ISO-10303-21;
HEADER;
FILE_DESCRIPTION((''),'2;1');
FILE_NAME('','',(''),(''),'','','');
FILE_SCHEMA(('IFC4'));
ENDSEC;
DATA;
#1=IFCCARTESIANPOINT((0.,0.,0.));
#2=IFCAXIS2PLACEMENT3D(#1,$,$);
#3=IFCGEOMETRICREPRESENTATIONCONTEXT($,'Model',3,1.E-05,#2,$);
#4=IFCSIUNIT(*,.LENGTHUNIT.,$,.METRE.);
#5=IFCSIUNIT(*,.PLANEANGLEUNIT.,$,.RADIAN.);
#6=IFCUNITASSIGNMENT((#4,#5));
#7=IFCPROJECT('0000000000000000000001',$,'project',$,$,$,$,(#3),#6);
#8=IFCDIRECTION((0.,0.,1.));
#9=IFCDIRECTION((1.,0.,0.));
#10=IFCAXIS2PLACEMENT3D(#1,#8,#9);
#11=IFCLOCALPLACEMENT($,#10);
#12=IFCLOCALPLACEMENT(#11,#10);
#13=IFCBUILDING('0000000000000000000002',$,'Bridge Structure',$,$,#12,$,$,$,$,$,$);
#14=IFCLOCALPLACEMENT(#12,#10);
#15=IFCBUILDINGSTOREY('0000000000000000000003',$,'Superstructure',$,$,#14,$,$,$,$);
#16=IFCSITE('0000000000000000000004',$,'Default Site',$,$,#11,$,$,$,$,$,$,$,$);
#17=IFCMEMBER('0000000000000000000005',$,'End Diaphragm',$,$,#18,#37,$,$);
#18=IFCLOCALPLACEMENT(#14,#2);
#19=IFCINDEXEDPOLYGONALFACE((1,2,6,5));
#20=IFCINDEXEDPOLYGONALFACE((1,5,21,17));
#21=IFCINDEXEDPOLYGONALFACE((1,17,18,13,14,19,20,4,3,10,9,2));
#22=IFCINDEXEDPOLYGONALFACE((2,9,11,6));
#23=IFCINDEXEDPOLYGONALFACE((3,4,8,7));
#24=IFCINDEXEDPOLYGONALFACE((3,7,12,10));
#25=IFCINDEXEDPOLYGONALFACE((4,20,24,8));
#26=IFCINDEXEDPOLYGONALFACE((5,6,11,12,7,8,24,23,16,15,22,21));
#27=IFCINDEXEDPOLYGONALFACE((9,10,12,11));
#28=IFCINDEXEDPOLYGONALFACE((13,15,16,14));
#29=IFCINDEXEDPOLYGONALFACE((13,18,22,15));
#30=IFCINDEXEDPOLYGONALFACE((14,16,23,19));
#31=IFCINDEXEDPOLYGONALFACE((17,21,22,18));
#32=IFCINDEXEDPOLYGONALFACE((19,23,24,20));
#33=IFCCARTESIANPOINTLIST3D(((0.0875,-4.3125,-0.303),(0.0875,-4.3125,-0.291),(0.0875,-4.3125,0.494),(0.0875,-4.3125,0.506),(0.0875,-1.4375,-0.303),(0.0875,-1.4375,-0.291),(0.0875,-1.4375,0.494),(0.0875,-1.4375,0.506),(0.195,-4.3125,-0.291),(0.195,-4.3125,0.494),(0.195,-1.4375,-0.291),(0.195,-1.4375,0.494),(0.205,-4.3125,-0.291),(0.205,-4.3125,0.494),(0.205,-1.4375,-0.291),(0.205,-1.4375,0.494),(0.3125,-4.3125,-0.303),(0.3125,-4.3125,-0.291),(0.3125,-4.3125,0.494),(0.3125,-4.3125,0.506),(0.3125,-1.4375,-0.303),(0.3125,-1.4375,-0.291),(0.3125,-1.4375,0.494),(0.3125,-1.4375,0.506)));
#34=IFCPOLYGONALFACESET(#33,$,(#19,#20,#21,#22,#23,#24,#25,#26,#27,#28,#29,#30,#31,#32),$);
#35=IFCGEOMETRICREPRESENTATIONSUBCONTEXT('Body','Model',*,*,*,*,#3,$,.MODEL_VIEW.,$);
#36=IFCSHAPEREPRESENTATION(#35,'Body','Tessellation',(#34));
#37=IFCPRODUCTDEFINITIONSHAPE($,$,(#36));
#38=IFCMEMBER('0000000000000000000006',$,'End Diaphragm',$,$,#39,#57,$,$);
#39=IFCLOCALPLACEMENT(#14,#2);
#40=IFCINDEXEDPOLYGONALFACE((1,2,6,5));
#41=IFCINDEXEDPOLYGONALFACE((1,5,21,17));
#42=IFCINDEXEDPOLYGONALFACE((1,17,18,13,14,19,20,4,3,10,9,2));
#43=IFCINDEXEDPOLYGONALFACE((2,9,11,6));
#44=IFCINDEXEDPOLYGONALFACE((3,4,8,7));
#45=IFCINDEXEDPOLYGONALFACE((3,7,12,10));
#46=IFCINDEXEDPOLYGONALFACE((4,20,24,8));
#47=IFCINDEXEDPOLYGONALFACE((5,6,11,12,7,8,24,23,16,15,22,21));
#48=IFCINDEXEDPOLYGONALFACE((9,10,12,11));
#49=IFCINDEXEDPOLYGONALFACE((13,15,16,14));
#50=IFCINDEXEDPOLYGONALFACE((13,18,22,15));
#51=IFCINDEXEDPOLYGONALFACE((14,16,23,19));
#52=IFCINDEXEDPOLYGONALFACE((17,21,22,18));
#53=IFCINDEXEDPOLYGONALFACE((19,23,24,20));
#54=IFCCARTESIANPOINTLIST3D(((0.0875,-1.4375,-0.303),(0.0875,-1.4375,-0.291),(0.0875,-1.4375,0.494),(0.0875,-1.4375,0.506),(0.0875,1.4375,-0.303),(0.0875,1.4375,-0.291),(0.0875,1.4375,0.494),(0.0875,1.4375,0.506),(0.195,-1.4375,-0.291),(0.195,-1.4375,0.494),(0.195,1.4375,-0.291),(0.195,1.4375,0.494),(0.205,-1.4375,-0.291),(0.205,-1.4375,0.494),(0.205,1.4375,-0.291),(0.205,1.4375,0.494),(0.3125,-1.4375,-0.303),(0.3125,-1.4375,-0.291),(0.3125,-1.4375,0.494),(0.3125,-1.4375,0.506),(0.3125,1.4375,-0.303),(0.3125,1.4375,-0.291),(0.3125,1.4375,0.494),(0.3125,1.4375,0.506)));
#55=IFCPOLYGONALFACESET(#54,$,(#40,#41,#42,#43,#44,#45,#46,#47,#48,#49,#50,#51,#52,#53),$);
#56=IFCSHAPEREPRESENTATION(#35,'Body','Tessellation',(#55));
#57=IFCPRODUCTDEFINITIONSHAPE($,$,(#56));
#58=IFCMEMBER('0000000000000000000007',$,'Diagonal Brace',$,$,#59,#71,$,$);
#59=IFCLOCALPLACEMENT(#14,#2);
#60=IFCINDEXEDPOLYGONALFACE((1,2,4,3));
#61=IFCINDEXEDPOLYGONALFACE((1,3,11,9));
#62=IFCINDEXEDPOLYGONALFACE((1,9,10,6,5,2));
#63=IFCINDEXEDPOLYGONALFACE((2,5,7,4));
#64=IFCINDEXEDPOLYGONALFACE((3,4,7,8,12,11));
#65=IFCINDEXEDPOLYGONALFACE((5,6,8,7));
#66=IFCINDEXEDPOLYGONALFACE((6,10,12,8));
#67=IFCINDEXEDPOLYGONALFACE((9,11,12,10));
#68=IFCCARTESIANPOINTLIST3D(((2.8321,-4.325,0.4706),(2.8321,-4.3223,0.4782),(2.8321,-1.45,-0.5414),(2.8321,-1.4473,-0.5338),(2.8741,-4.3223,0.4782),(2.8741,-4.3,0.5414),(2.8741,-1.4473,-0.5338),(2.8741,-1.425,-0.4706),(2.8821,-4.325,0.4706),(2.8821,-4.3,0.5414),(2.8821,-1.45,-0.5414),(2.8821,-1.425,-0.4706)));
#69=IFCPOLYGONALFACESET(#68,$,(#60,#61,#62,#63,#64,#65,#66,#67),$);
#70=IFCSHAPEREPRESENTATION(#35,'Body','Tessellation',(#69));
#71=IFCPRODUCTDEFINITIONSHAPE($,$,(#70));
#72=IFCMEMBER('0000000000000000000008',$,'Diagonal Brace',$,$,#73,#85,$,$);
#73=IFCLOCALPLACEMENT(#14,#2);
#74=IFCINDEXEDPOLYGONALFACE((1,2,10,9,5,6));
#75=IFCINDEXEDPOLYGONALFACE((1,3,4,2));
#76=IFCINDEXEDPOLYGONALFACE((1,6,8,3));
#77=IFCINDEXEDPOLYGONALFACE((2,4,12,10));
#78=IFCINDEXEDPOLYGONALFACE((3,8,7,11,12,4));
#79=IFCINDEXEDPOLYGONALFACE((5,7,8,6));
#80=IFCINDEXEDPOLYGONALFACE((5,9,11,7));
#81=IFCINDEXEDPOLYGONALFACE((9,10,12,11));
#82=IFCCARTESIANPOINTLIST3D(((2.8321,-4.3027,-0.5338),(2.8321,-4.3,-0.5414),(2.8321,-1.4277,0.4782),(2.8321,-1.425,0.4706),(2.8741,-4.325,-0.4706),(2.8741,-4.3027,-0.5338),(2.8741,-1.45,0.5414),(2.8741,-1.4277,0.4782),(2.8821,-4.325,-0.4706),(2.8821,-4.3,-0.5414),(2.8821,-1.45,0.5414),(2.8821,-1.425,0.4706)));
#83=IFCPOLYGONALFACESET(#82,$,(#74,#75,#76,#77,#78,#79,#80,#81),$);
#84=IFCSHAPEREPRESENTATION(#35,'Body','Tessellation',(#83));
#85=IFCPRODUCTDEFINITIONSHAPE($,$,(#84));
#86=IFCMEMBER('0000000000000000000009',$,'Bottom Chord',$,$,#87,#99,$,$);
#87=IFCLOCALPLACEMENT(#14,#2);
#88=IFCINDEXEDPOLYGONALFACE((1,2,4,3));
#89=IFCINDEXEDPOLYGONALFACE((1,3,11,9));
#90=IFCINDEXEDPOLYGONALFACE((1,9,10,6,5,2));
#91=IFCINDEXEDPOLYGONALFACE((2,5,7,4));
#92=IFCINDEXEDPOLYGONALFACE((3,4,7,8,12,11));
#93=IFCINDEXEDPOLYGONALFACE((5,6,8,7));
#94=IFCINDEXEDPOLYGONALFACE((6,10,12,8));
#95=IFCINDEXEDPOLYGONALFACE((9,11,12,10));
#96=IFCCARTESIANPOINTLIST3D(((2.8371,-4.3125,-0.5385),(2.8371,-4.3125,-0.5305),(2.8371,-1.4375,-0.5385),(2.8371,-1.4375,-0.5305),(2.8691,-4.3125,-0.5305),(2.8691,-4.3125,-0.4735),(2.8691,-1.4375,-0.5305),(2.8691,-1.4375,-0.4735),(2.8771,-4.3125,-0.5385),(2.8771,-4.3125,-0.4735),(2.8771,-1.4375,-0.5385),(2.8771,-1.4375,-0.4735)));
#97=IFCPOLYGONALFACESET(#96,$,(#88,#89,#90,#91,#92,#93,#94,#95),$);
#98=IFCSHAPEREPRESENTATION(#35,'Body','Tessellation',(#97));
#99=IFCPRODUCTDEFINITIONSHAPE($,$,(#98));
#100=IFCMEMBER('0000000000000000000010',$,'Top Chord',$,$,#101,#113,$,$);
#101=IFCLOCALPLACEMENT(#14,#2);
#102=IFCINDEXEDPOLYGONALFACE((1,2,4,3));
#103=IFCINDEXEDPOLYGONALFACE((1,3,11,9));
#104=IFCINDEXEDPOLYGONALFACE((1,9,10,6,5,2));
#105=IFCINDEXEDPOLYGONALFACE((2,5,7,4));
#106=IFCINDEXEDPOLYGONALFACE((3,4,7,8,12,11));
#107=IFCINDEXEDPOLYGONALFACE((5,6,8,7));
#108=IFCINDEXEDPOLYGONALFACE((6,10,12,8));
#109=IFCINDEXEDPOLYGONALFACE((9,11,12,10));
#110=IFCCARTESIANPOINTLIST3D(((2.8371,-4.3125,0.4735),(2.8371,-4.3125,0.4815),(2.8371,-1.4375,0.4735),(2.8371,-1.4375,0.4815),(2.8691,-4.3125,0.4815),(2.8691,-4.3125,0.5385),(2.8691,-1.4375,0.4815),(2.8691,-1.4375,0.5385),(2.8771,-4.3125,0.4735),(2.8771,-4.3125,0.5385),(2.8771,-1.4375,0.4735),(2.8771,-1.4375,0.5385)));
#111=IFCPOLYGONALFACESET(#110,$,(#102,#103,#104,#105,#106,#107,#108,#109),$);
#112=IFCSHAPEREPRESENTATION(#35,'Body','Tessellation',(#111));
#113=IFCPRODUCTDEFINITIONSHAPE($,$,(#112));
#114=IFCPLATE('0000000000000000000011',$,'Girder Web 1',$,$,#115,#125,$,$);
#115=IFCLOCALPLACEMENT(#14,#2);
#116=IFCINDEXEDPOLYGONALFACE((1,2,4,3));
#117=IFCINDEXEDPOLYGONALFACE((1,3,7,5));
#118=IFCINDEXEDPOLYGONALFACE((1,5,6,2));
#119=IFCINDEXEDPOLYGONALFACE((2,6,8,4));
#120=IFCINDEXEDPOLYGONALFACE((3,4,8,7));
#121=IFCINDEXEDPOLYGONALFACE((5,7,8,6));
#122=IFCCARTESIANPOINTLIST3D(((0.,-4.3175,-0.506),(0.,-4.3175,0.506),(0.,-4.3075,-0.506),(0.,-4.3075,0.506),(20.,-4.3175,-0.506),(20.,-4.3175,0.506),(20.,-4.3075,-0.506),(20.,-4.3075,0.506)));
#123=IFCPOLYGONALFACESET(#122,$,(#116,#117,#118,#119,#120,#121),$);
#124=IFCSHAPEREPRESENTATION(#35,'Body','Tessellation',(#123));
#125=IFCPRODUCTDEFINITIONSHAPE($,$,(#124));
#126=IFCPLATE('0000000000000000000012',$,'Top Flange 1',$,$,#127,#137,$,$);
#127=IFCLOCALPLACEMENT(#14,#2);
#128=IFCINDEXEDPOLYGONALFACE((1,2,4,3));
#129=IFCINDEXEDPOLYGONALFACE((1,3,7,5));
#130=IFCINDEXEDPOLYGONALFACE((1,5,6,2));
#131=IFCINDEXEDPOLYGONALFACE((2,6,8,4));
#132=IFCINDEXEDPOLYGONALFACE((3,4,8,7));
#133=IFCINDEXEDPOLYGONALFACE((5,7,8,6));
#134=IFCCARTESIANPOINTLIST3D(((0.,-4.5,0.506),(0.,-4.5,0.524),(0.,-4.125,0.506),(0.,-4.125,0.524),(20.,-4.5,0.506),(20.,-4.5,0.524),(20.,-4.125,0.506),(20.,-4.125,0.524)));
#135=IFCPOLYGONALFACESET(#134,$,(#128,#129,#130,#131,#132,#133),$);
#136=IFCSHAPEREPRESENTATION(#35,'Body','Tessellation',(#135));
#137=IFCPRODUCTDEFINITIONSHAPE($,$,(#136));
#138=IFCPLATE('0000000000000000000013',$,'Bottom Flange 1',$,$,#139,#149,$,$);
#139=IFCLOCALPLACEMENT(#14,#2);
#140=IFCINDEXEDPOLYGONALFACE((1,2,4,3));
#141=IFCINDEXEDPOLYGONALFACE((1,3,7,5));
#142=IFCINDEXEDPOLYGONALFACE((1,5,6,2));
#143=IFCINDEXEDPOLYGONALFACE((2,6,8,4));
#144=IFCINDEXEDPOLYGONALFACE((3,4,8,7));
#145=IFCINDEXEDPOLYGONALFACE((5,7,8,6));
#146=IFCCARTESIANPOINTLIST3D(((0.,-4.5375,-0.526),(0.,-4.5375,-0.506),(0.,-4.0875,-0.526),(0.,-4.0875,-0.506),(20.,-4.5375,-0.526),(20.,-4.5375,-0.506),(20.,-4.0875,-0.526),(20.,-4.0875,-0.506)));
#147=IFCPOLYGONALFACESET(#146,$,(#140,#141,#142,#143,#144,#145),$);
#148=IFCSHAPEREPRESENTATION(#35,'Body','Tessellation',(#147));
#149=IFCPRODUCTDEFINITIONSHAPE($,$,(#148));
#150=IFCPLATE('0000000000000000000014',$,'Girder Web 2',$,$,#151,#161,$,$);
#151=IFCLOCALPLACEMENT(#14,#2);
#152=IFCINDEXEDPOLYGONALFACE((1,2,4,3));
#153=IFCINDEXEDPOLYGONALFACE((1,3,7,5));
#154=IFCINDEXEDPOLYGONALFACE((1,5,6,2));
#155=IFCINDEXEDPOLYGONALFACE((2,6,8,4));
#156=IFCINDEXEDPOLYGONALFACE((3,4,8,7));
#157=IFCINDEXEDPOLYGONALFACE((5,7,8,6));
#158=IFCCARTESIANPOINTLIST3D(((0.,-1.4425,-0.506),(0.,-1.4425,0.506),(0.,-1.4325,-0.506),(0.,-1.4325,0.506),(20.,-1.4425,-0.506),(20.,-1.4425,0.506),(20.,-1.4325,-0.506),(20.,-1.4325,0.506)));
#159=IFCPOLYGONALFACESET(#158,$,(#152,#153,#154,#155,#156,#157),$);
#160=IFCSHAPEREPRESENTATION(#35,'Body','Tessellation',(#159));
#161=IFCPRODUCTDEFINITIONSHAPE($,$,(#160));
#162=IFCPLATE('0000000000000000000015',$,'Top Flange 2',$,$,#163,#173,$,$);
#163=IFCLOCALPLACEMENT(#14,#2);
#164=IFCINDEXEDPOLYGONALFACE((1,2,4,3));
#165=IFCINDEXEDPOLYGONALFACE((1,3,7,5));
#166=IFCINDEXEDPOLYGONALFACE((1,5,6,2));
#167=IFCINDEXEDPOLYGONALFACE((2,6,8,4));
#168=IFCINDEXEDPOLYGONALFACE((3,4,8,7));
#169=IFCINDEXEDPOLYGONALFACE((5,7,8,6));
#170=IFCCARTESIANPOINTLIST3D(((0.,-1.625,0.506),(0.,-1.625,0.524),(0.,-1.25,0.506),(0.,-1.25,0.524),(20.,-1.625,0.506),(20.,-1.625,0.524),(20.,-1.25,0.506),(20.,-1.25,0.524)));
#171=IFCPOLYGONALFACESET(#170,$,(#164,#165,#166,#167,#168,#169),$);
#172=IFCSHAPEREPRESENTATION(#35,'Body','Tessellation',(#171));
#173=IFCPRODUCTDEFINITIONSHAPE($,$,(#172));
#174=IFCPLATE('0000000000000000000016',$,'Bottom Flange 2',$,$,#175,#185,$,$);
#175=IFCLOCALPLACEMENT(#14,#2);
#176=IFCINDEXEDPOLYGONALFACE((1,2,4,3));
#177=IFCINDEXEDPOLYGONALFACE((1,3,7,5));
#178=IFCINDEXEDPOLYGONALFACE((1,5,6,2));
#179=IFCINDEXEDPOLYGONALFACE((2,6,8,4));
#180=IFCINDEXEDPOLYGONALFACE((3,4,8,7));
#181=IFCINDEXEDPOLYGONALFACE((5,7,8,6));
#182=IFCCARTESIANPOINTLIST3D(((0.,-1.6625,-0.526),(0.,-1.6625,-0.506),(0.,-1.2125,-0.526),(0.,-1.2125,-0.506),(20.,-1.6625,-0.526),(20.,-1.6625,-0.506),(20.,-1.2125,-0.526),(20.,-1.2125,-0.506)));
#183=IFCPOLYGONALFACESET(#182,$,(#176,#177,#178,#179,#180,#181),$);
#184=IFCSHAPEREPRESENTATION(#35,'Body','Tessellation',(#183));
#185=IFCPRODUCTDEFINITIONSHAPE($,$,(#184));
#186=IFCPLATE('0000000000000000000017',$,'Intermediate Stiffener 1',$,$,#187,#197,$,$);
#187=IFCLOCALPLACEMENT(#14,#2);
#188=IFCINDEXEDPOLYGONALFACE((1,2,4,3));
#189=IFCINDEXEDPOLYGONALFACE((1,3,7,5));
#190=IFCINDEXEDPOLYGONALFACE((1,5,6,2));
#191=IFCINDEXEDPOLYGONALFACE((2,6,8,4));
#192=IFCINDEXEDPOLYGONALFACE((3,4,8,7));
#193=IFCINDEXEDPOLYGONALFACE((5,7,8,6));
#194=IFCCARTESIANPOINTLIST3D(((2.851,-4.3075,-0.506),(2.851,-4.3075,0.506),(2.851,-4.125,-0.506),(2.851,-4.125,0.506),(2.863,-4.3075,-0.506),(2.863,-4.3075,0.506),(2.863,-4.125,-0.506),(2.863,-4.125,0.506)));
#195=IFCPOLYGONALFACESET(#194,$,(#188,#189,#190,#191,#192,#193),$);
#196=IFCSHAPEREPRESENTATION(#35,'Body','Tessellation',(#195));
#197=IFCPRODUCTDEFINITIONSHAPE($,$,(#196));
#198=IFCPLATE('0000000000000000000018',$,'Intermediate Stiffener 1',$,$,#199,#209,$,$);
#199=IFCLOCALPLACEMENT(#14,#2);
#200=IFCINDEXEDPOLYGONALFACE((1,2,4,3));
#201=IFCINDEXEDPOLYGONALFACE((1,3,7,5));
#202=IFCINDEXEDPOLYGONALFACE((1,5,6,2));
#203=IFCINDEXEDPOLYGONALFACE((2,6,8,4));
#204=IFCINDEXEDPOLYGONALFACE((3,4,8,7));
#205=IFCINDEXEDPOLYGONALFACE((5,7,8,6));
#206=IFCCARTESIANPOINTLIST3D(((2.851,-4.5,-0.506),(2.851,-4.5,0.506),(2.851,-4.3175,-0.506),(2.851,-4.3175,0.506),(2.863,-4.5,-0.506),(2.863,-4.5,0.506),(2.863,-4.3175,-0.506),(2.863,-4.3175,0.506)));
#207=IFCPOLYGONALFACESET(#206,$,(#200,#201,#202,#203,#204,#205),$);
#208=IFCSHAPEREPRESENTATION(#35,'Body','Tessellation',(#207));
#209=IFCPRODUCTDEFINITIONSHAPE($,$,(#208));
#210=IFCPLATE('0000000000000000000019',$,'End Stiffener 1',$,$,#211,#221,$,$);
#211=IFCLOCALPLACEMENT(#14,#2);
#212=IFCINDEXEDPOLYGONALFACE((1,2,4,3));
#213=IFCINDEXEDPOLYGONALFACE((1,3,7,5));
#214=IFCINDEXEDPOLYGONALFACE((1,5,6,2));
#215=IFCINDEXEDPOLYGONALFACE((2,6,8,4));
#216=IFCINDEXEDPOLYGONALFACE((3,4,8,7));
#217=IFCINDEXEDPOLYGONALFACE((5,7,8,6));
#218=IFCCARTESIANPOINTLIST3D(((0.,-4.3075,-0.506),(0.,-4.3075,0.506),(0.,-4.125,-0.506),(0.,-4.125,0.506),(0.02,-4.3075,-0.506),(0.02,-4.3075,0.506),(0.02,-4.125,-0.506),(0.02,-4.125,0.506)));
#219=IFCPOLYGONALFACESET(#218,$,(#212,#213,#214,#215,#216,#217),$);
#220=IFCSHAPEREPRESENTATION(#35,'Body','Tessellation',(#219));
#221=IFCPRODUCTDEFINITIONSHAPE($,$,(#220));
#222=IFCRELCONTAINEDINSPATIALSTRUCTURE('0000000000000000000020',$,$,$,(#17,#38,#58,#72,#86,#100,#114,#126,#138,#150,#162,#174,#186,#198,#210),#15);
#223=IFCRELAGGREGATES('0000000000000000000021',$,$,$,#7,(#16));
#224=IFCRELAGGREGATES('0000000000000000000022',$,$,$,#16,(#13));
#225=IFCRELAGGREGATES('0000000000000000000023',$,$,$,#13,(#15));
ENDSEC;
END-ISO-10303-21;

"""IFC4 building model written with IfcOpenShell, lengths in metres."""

from ifc_helpers import new_model, si_unit, frame, origin, origin_with_axes, origin_2d_with_axis, place, context, subcontext, project, spatial, rectangle, i_section, l_section, extrude, element, save


model = new_model("IFC4")

# Units and contexts
model_context = context("Model", 3, precision=1e-05, world=origin())
body_context = subcontext(model_context, "Body", "Model", "MODEL_VIEW")
ifc_project = project(units=[si_unit("LENGTHUNIT", "METRE"), si_unit("PLANEANGLEUNIT", "RADIAN")], contexts=[model_context])

# Site, building, storey
site_placement = place(None, origin_with_axes())
site = spatial("IfcSite", under=ifc_project, at=site_placement, Name="Default Site")
building_placement = place(site_placement, origin_with_axes())
building = spatial("IfcBuilding", under=site, at=building_placement, Name="Bridge Structure")
storey_placement = place(building_placement, origin_with_axes())
storey = spatial("IfcBuildingStorey", under=building, at=storey_placement, Name="Superstructure")

# Members
for number, where, z_axis, x_axis, name in (
    (1, (0.2, -4.3125, 0.1015), (0.0, 1.0, 0.0), (-1.0, 0.0, 0.0), "End Diaphragm"),
    (2, (0.2, -1.4375, 0.1015), (0.0, 1.0, 0.0), (-1.0, 0.0, 0.0), "End Diaphragm"),
):
    element("IfcMember", number, at=place(storey_placement, frame(where, z_axis=z_axis, x_axis=x_axis)), inside=storey, Name=name, context=body_context, shape_type="SweptSolid", body=[
        extrude(i_section(OverallWidth=0.225, OverallDepth=0.809, WebThickness=0.01, FlangeThickness=0.012, at=origin_2d_with_axis()), origin_with_axes(), (0.0, 0.0, 1.0), 2.875),
    ])
for number, where, z_axis, x_axis, name in (
    (3, (2.8571, -4.3125, 0.506), (0.0, 0.943269, -0.332031), (-1.0, 0.0, 0.0), "Diagonal Brace"),
    (4, (2.8571, -4.3125, -0.506), (0.0, 0.943269, 0.332031), (-1.0, 0.0, 0.0), "Diagonal Brace"),
):
    element("IfcMember", number, at=place(storey_placement, frame(where, z_axis=z_axis, x_axis=x_axis)), inside=storey, Name=name, context=body_context, shape_type="SweptSolid", body=[
        extrude(l_section(Depth=0.075, Width=0.05, Thickness=0.008, at=origin_2d_with_axis()), origin_with_axes(), (0.0, 0.0, 1.0), 3.0479),
    ])
for number, where, z_axis, x_axis, name in (
    (5, (2.8571, -4.3125, -0.506), (0.0, 1.0, 0.0), (-1.0, 0.0, 0.0), "Bottom Chord"),
    (6, (2.8571, -4.3125, 0.506), (0.0, 1.0, 0.0), (-1.0, 0.0, 0.0), "Top Chord"),
):
    element("IfcMember", number, at=place(storey_placement, frame(where, z_axis=z_axis, x_axis=x_axis)), inside=storey, Name=name, context=body_context, shape_type="SweptSolid", body=[
        extrude(l_section(Depth=0.065, Width=0.04, Thickness=0.008, at=origin_2d_with_axis()), origin_with_axes(), (0.0, 0.0, 1.0), 2.875),
    ])

# Plates
plate_1_placement = place(storey_placement, frame((0.0, -4.3125, 0.0), z_axis=(1.0, 0.0, 0.0), x_axis=(0.0, 1.0, 0.0)))
element("IfcPlate", 7, at=plate_1_placement, inside=storey, Name="Girder Web 1", context=body_context, shape_type="SweptSolid", body=[
    extrude(rectangle(XDim=0.01, YDim=1.012, at=origin_2d_with_axis()), origin_with_axes(), (0.0, 0.0, 1.0), 20.0),
])
plate_2_placement = place(storey_placement, frame((0.0, -4.3125, 0.515), z_axis=(1.0, 0.0, 0.0), x_axis=(0.0, 1.0, 0.0)))
element("IfcPlate", 8, at=plate_2_placement, inside=storey, Name="Top Flange 1", context=body_context, shape_type="SweptSolid", body=[
    extrude(rectangle(XDim=0.375, YDim=0.018, at=origin_2d_with_axis()), origin_with_axes(), (0.0, 0.0, 1.0), 20.0),
])
plate_3_placement = place(storey_placement, frame((0.0, -4.3125, -0.516), z_axis=(1.0, 0.0, 0.0), x_axis=(0.0, 1.0, 0.0)))
element("IfcPlate", 9, at=plate_3_placement, inside=storey, Name="Bottom Flange 1", context=body_context, shape_type="SweptSolid", body=[
    extrude(rectangle(XDim=0.45, YDim=0.02, at=origin_2d_with_axis()), origin_with_axes(), (0.0, 0.0, 1.0), 20.0),
])
plate_4_placement = place(storey_placement, frame((0.0, -1.4375, 0.0), z_axis=(1.0, 0.0, 0.0), x_axis=(0.0, 1.0, 0.0)))
element("IfcPlate", 10, at=plate_4_placement, inside=storey, Name="Girder Web 2", context=body_context, shape_type="SweptSolid", body=[
    extrude(rectangle(XDim=0.01, YDim=1.012, at=origin_2d_with_axis()), origin_with_axes(), (0.0, 0.0, 1.0), 20.0),
])
plate_5_placement = place(storey_placement, frame((0.0, -1.4375, 0.515), z_axis=(1.0, 0.0, 0.0), x_axis=(0.0, 1.0, 0.0)))
element("IfcPlate", 11, at=plate_5_placement, inside=storey, Name="Top Flange 2", context=body_context, shape_type="SweptSolid", body=[
    extrude(rectangle(XDim=0.375, YDim=0.018, at=origin_2d_with_axis()), origin_with_axes(), (0.0, 0.0, 1.0), 20.0),
])
plate_6_placement = place(storey_placement, frame((0.0, -1.4375, -0.516), z_axis=(1.0, 0.0, 0.0), x_axis=(0.0, 1.0, 0.0)))
element("IfcPlate", 12, at=plate_6_placement, inside=storey, Name="Bottom Flange 2", context=body_context, shape_type="SweptSolid", body=[
    extrude(rectangle(XDim=0.45, YDim=0.02, at=origin_2d_with_axis()), origin_with_axes(), (0.0, 0.0, 1.0), 20.0),
])
for number, where, z_axis, x_axis, name in (
    (13, (2.857, -4.2163, -0.506), (0.0, 0.0, 1.0), (1.0, 0.0, 0.0), "Intermediate Stiffener 1"),
    (14, (2.857, -4.4088, -0.506), (0.0, 0.0, 1.0), (1.0, 0.0, 0.0), "Intermediate Stiffener 1"),
):
    element("IfcPlate", number, at=place(storey_placement, frame(where, z_axis=z_axis, x_axis=x_axis)), inside=storey, Name=name, context=body_context, shape_type="SweptSolid", body=[
        extrude(rectangle(XDim=0.012, YDim=0.1825, at=origin_2d_with_axis()), origin_with_axes(), (0.0, 0.0, 1.0), 1.012),
    ])
for number, where, z_axis, x_axis, name in (
    (15, (0.01, -4.2163, -0.506), (0.0, 0.0, 1.0), (1.0, 0.0, 0.0), "End Stiffener 1"),
):
    element("IfcPlate", number, at=place(storey_placement, frame(where, z_axis=z_axis, x_axis=x_axis)), inside=storey, Name=name, context=body_context, shape_type="SweptSolid", body=[
        extrude(rectangle(XDim=0.02, YDim=0.1825, at=origin_2d_with_axis()), origin_with_axes(), (0.0, 0.0, 1.0), 1.012),
    ])

save(model, "model.ifc")
